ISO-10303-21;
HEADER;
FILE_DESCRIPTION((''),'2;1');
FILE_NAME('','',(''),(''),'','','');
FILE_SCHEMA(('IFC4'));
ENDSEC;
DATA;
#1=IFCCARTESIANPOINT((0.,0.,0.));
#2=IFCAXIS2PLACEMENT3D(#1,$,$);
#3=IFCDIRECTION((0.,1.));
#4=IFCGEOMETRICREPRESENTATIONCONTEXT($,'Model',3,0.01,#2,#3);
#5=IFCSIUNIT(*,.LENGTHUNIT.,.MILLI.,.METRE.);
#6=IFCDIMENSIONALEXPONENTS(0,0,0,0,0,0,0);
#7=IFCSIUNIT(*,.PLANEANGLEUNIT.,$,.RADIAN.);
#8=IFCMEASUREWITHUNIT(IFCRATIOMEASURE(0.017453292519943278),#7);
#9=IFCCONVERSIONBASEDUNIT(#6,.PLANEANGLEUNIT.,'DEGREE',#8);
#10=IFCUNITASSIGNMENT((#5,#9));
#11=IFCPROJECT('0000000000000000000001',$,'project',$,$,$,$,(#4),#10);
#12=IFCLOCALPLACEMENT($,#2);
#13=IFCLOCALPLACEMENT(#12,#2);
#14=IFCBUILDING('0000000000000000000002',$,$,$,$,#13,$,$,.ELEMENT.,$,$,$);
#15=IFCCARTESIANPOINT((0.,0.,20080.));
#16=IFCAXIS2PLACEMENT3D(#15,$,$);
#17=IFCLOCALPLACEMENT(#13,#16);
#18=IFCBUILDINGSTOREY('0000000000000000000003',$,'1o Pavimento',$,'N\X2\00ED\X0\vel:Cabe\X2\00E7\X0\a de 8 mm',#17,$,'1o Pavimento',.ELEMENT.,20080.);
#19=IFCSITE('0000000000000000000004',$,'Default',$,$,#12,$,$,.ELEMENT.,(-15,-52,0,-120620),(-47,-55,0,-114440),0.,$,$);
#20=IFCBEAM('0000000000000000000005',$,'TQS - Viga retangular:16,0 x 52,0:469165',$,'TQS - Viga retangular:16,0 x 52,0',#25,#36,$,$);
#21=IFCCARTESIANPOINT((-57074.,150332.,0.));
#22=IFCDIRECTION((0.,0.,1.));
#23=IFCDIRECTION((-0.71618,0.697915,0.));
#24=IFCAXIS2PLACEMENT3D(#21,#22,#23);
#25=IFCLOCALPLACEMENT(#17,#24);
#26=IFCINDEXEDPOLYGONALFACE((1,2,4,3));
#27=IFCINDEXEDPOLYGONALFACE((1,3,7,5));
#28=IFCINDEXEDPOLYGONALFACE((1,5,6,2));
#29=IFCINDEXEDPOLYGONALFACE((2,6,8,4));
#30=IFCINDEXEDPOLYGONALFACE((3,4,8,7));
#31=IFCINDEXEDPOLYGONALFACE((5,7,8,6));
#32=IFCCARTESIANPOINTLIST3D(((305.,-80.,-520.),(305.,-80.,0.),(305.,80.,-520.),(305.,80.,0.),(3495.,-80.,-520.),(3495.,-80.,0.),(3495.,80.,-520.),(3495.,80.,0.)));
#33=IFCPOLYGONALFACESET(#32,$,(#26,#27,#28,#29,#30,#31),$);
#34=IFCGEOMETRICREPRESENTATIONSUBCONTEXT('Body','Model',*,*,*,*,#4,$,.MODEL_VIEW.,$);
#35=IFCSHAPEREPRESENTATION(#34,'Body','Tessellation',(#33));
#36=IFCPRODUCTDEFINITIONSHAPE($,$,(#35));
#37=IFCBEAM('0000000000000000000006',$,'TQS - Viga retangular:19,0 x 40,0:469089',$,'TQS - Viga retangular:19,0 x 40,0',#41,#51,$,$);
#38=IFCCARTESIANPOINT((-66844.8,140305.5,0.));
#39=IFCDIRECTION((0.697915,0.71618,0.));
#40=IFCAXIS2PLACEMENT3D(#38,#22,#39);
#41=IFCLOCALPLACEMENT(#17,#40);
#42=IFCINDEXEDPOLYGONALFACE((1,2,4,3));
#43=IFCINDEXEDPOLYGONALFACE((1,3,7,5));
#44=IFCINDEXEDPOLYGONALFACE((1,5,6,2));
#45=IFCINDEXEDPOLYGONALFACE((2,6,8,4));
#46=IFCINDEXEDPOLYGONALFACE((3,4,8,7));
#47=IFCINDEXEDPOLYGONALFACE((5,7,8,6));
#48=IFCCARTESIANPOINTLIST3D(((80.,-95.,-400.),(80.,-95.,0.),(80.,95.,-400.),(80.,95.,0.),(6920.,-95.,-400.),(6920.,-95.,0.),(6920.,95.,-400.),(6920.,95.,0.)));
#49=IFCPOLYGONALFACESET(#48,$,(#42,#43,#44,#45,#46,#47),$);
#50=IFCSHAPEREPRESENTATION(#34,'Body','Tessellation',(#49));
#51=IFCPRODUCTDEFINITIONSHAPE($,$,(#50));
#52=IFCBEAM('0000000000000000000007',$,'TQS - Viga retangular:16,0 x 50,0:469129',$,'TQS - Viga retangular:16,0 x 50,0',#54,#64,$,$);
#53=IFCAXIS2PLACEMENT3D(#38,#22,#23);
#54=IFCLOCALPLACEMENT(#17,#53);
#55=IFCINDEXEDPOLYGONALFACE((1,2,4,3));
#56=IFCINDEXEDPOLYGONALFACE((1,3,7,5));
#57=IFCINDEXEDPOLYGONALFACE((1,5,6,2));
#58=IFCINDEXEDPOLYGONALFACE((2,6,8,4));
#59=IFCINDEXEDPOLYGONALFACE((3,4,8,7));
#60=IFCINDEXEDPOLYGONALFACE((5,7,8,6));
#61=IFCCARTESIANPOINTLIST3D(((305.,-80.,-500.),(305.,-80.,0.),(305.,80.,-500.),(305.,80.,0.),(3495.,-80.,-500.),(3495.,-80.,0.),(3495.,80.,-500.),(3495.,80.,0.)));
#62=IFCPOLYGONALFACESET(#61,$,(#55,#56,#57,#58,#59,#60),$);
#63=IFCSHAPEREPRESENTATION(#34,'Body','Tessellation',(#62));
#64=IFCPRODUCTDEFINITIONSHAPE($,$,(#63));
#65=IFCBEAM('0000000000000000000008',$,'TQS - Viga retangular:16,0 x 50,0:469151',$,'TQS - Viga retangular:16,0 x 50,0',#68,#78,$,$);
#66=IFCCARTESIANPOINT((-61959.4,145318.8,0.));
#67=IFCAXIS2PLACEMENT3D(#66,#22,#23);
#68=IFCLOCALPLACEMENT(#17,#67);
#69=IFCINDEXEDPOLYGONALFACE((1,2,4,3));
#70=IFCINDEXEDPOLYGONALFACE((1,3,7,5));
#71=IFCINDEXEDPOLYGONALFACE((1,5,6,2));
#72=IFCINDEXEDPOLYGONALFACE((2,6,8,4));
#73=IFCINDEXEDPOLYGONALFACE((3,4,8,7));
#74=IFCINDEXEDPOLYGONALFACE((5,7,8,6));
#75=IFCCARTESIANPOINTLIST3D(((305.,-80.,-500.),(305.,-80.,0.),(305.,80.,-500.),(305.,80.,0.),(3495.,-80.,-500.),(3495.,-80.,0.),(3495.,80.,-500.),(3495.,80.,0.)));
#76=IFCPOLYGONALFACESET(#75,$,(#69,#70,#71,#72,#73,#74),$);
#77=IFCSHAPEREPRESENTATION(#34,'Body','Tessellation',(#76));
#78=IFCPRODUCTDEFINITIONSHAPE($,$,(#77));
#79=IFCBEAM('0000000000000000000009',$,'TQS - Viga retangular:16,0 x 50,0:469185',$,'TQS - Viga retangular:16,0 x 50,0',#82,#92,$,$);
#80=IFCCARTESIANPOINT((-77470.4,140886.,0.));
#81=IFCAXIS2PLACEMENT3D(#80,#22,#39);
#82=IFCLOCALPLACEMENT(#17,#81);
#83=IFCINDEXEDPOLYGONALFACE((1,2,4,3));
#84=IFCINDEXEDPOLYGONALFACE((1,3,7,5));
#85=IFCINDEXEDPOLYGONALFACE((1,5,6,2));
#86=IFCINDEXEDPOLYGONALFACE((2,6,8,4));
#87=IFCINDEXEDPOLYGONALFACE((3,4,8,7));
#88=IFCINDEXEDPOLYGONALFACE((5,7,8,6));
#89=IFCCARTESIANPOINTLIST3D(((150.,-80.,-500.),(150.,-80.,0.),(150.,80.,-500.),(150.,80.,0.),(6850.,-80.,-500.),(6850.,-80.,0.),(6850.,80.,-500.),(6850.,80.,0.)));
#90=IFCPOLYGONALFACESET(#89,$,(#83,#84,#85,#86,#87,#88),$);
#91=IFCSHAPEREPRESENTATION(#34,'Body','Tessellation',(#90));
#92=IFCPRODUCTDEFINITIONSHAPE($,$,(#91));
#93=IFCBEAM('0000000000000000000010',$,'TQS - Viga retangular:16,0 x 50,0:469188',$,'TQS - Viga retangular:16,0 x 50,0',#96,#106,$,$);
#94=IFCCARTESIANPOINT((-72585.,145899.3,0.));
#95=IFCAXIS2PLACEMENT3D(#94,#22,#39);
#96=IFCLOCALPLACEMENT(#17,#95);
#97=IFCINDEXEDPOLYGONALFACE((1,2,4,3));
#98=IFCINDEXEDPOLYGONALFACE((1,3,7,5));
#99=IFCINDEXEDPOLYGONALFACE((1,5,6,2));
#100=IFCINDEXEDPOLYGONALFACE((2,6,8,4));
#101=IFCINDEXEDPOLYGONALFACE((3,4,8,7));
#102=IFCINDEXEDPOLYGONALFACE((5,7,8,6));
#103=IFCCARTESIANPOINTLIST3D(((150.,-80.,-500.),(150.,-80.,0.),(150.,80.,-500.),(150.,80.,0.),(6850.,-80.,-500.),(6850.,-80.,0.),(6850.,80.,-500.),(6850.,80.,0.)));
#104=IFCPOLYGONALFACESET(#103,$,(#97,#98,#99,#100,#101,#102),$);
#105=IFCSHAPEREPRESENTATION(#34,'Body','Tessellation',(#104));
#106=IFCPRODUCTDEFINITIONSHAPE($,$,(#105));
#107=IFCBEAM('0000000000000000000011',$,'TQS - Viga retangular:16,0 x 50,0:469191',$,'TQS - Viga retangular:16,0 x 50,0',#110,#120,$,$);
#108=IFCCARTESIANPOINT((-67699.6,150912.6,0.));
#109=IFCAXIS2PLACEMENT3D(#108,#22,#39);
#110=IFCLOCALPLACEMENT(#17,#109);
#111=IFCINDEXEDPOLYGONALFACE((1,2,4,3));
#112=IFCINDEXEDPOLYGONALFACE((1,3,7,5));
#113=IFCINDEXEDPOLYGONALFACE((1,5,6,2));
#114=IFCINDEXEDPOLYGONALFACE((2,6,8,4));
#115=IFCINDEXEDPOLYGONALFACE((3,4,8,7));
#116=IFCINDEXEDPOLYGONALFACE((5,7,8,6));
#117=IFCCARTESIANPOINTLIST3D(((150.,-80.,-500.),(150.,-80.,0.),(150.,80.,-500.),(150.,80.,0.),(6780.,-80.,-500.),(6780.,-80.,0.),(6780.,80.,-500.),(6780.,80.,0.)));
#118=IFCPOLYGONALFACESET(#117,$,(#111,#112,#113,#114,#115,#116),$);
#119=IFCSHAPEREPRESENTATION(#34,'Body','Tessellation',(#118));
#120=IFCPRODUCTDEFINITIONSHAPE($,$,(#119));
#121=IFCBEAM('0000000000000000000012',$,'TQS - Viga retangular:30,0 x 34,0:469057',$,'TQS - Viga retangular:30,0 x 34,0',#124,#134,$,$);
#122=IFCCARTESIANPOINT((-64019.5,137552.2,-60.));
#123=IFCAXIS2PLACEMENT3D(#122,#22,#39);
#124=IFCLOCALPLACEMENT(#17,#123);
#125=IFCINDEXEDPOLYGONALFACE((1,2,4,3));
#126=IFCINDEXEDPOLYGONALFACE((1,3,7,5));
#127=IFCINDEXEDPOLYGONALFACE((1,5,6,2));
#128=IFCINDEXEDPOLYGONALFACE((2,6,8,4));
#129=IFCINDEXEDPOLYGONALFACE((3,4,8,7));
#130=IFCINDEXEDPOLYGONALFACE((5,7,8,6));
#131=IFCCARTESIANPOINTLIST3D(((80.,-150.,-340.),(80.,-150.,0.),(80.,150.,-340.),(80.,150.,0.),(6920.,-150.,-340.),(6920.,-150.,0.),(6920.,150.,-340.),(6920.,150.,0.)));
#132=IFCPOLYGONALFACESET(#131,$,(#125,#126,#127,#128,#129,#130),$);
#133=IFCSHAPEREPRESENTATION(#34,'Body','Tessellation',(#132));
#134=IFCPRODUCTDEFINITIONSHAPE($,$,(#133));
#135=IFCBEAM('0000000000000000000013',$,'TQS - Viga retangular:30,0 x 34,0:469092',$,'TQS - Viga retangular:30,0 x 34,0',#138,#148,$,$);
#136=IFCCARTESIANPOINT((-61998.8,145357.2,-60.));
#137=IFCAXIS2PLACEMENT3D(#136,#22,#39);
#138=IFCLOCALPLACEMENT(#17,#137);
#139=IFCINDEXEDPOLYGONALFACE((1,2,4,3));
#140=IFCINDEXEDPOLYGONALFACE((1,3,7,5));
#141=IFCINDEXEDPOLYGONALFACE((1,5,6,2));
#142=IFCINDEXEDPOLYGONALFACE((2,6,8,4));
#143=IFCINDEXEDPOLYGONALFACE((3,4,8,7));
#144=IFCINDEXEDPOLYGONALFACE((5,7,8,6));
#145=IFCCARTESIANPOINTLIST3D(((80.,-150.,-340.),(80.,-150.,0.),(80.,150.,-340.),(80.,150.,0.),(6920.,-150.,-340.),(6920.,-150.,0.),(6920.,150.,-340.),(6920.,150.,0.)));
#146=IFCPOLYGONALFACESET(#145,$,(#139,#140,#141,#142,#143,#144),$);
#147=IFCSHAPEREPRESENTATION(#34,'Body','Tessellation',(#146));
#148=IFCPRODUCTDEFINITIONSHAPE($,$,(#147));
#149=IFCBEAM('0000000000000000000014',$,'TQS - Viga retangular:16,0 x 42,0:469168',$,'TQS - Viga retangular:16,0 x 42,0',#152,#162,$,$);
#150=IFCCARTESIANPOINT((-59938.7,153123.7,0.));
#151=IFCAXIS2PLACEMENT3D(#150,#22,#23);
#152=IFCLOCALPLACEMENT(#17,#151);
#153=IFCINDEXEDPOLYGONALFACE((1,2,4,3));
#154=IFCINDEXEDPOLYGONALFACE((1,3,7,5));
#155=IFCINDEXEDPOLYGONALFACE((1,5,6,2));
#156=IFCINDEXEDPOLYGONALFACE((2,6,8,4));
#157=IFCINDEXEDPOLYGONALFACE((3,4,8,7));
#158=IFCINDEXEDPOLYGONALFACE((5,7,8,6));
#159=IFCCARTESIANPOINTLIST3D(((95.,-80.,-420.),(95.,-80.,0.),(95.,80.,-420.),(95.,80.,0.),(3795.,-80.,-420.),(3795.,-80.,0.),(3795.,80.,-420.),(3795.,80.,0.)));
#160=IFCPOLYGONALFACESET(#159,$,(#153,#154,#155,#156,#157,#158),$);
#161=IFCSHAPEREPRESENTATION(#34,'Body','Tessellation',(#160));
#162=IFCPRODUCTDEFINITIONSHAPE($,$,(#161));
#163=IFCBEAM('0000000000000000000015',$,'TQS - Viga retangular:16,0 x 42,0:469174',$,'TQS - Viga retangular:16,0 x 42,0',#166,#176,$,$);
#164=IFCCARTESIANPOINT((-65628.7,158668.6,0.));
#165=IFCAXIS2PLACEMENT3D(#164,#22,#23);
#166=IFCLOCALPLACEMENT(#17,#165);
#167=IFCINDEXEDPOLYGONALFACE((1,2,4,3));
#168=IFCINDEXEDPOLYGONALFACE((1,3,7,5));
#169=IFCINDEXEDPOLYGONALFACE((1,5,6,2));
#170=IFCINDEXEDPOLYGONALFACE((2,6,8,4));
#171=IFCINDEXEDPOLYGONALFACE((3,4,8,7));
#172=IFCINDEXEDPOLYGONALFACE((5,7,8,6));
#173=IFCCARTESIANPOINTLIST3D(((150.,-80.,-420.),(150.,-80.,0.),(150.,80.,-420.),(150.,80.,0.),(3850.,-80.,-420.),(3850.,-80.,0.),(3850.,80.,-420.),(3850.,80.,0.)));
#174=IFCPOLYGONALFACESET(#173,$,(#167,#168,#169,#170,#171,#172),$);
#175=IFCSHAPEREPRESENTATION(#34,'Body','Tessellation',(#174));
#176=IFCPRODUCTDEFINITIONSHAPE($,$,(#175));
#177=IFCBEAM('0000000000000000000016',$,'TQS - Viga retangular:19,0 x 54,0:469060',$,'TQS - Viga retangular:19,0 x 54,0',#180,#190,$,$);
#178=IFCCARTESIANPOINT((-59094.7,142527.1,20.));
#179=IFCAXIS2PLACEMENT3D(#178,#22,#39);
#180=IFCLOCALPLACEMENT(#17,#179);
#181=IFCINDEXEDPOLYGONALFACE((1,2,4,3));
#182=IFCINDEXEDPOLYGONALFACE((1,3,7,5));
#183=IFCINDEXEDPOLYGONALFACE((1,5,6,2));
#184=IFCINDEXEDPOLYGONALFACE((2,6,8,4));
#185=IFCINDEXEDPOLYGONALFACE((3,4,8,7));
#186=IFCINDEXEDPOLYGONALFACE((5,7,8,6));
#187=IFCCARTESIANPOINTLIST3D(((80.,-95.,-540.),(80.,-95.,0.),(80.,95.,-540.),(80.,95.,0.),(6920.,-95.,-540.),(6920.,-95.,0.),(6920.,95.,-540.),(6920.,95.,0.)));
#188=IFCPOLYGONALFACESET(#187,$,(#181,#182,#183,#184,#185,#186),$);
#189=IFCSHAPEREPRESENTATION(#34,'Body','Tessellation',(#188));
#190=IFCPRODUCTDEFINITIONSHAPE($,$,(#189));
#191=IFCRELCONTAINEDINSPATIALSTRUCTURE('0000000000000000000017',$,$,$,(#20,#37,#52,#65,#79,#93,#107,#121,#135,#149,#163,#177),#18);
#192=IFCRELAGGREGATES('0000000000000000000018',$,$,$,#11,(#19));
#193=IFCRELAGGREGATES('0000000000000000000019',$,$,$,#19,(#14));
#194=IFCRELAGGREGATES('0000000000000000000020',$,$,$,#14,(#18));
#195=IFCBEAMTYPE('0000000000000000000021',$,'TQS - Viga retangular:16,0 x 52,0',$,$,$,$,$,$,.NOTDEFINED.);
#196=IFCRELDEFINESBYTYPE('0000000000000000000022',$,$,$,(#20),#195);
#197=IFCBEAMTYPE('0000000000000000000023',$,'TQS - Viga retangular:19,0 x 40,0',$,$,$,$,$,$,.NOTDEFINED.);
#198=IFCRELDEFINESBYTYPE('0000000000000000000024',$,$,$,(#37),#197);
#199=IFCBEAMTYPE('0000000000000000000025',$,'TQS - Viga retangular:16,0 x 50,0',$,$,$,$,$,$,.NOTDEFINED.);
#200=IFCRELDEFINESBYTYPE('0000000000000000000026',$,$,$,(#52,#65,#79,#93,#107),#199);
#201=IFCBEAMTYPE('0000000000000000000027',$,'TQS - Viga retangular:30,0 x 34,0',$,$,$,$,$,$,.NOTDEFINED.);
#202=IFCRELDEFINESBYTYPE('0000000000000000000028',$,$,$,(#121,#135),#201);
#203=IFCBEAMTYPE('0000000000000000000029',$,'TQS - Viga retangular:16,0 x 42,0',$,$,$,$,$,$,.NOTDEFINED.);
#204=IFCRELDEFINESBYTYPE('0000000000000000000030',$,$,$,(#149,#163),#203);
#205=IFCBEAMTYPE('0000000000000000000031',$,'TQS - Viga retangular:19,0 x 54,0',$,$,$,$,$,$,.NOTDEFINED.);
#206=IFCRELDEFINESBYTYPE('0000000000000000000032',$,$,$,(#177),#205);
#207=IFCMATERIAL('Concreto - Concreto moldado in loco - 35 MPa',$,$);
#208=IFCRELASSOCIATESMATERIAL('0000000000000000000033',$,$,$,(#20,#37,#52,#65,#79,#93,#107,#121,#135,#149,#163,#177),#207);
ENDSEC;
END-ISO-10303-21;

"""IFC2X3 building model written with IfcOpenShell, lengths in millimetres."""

from ifc_helpers import new_model, entity, si_unit, converted_unit, direction, frame, frame_2d, origin, origin_2d_with_axis, place, context, subcontext, project, spatial, rectangle, extrude, material, type_object, element, save


model = new_model("IFC2X3")

# Units and contexts
model_context = context("Model", 3, precision=0.01, world=origin(), true_north=direction((0.0, 1.0)))
body_context = subcontext(model_context, "Body", "Model", "MODEL_VIEW")
ifc_project = project(units=[si_unit("LENGTHUNIT", "METRE", prefix="MILLI"), converted_unit("PLANEANGLEUNIT", "DEGREE", entity("IfcRatioMeasure", 0.017453292519943278), si_unit("PLANEANGLEUNIT", "RADIAN"), dimensions=[0, 0, 0, 0, 0, 0, 0])], contexts=[model_context])

# Site, building, storey
site_placement = place(None, origin())
site = spatial("IfcSite", under=ifc_project, at=site_placement, Name="Default", CompositionType="ELEMENT", RefLatitude=(-15, -52, 0, -120620), RefLongitude=(-47, -55, 0, -114440), RefElevation=0.0)
building_placement = place(site_placement, origin())
building = spatial("IfcBuilding", under=site, at=building_placement, CompositionType="ELEMENT")
storey_placement = place(building_placement, frame((0.0, 0.0, 20080.0)))
storey = spatial("IfcBuildingStorey", under=building, at=storey_placement, Name="1o Pavimento", ObjectType="Nível:Cabeça de 8 mm", LongName="1o Pavimento", CompositionType="ELEMENT", Elevation=20080.0)

# Beams
ifc_material_1 = material(Name="Concreto - Concreto moldado in loco - 35 MPa")
beam_type_1 = type_object("IfcBeamType", Name="TQS - Viga retangular:16,0 x 52,0", PredefinedType="NOTDEFINED")
beam_1_placement = place(storey_placement, frame((-57074.0, 150332.0, 0.0), z_axis=(0.0, 0.0, 1.0), x_axis=(-0.71618, 0.697915, 0.0)))
element("IfcBeam", 1, at=beam_1_placement, inside=storey, type_object=beam_type_1, material=ifc_material_1, Name="TQS - Viga retangular:16,0 x 52,0:469165", ObjectType="TQS - Viga retangular:16,0 x 52,0", context=body_context, shape_type="SweptSolid", body=[
    extrude(rectangle(XDim=520.0, YDim=160.0, at=frame_2d((0.0, 0.0), x_axis=(1.0, 0.0))), frame((305.0, 0.0, -260.0), z_axis=(1.0, 0.0, 0.0), x_axis=(0.0, 0.0, -1.0)), (0.0, 0.0, 1.0), 3190.0),
])
beam_type_2 = type_object("IfcBeamType", Name="TQS - Viga retangular:19,0 x 40,0", PredefinedType="NOTDEFINED")
beam_2_placement = place(storey_placement, frame((-66844.8, 140305.5, 0.0), z_axis=(0.0, 0.0, 1.0), x_axis=(0.697915, 0.71618, 0.0)))
element("IfcBeam", 2, at=beam_2_placement, inside=storey, type_object=beam_type_2, material=ifc_material_1, Name="TQS - Viga retangular:19,0 x 40,0:469089", ObjectType="TQS - Viga retangular:19,0 x 40,0", context=body_context, shape_type="SweptSolid", body=[
    extrude(rectangle(XDim=400.0, YDim=190.0, at=frame_2d((0.0, 0.0), x_axis=(1.0, 0.0))), frame((80.0, 0.0, -200.0), z_axis=(1.0, 0.0, 0.0), x_axis=(0.0, 0.0, -1.0)), (0.0, 0.0, 1.0), 6840.0),
])
beam_type_3 = type_object("IfcBeamType", Name="TQS - Viga retangular:16,0 x 50,0", PredefinedType="NOTDEFINED")
beam_3_placement = place(storey_placement, frame((-66844.8, 140305.5, 0.0), z_axis=(0.0, 0.0, 1.0), x_axis=(-0.71618, 0.697915, 0.0)))
element("IfcBeam", 3, at=beam_3_placement, inside=storey, type_object=beam_type_3, material=ifc_material_1, Name="TQS - Viga retangular:16,0 x 50,0:469129", ObjectType="TQS - Viga retangular:16,0 x 50,0", context=body_context, shape_type="SweptSolid", body=[
    extrude(rectangle(XDim=500.0, YDim=160.0, at=frame_2d((0.0, 0.0), x_axis=(1.0, 0.0))), frame((305.0, 0.0, -250.0), z_axis=(1.0, 0.0, 0.0), x_axis=(0.0, 0.0, -1.0)), (0.0, 0.0, 1.0), 3190.0),
])
beam_4_placement = place(storey_placement, frame((-61959.4, 145318.8, 0.0), z_axis=(0.0, 0.0, 1.0), x_axis=(-0.71618, 0.697915, 0.0)))
element("IfcBeam", 4, at=beam_4_placement, inside=storey, type_object=beam_type_3, material=ifc_material_1, Name="TQS - Viga retangular:16,0 x 50,0:469151", ObjectType="TQS - Viga retangular:16,0 x 50,0", context=body_context, shape_type="SweptSolid", body=[
    extrude(rectangle(XDim=500.0, YDim=160.0, at=frame_2d((0.0, 0.0), x_axis=(1.0, 0.0))), frame((305.0, 0.0, -250.0), z_axis=(1.0, 0.0, 0.0), x_axis=(0.0, 0.0, -1.0)), (0.0, 0.0, 1.0), 3190.0),
])
beam_5_placement = place(storey_placement, frame((-77470.4, 140886.0, 0.0), z_axis=(0.0, 0.0, 1.0), x_axis=(0.697915, 0.71618, 0.0)))
element("IfcBeam", 5, at=beam_5_placement, inside=storey, type_object=beam_type_3, material=ifc_material_1, Name="TQS - Viga retangular:16,0 x 50,0:469185", ObjectType="TQS - Viga retangular:16,0 x 50,0", context=body_context, shape_type="SweptSolid", body=[
    extrude(rectangle(XDim=500.0, YDim=160.0, at=frame_2d((0.0, 0.0), x_axis=(1.0, 0.0))), frame((150.0, 0.0, -250.0), z_axis=(1.0, 0.0, 0.0), x_axis=(0.0, 0.0, -1.0)), (0.0, 0.0, 1.0), 6700.0),
])
beam_6_placement = place(storey_placement, frame((-72585.0, 145899.3, 0.0), z_axis=(0.0, 0.0, 1.0), x_axis=(0.697915, 0.71618, 0.0)))
element("IfcBeam", 6, at=beam_6_placement, inside=storey, type_object=beam_type_3, material=ifc_material_1, Name="TQS - Viga retangular:16,0 x 50,0:469188", ObjectType="TQS - Viga retangular:16,0 x 50,0", context=body_context, shape_type="SweptSolid", body=[
    extrude(rectangle(XDim=500.0, YDim=160.0, at=frame_2d((0.0, 0.0), x_axis=(1.0, 0.0))), frame((150.0, 0.0, -250.0), z_axis=(1.0, 0.0, 0.0), x_axis=(0.0, 0.0, -1.0)), (0.0, 0.0, 1.0), 6700.0),
])
beam_7_placement = place(storey_placement, frame((-67699.6, 150912.6, 0.0), z_axis=(0.0, 0.0, 1.0), x_axis=(0.697915, 0.71618, 0.0)))
element("IfcBeam", 7, at=beam_7_placement, inside=storey, type_object=beam_type_3, material=ifc_material_1, Name="TQS - Viga retangular:16,0 x 50,0:469191", ObjectType="TQS - Viga retangular:16,0 x 50,0", context=body_context, shape_type="SweptSolid", body=[
    extrude(rectangle(XDim=500.0, YDim=160.0, at=frame_2d((0.0, 0.0), x_axis=(1.0, 0.0))), frame((150.0, 0.0, -250.0), z_axis=(1.0, 0.0, 0.0), x_axis=(0.0, 0.0, -1.0)), (0.0, 0.0, 1.0), 6630.0),
])
beam_type_4 = type_object("IfcBeamType", Name="TQS - Viga retangular:30,0 x 34,0", PredefinedType="NOTDEFINED")
beam_8_placement = place(storey_placement, frame((-64019.5, 137552.2, -60.0), z_axis=(0.0, 0.0, 1.0), x_axis=(0.697915, 0.71618, 0.0)))
element("IfcBeam", 8, at=beam_8_placement, inside=storey, type_object=beam_type_4, material=ifc_material_1, Name="TQS - Viga retangular:30,0 x 34,0:469057", ObjectType="TQS - Viga retangular:30,0 x 34,0", context=body_context, shape_type="SweptSolid", body=[
    extrude(rectangle(XDim=340.0, YDim=300.0, at=frame_2d((0.0, 0.0), x_axis=(1.0, 0.0))), frame((80.0, 0.0, -170.0), z_axis=(1.0, 0.0, 0.0), x_axis=(0.0, 0.0, -1.0)), (0.0, 0.0, 1.0), 6840.0),
])
beam_9_placement = place(storey_placement, frame((-61998.8, 145357.2, -60.0), z_axis=(0.0, 0.0, 1.0), x_axis=(0.697915, 0.71618, 0.0)))
element("IfcBeam", 9, at=beam_9_placement, inside=storey, type_object=beam_type_4, material=ifc_material_1, Name="TQS - Viga retangular:30,0 x 34,0:469092", ObjectType="TQS - Viga retangular:30,0 x 34,0", context=body_context, shape_type="SweptSolid", body=[
    extrude(rectangle(XDim=340.0, YDim=300.0, at=origin_2d_with_axis()), frame((80.0, 0.0, -170.0), z_axis=(1.0, 0.0, 0.0), x_axis=(0.0, 0.0, -1.0)), (0.0, 0.0, 1.0), 6840.0),
])
beam_type_5 = type_object("IfcBeamType", Name="TQS - Viga retangular:16,0 x 42,0", PredefinedType="NOTDEFINED")
beam_10_placement = place(storey_placement, frame((-59938.7, 153123.7, 0.0), z_axis=(0.0, 0.0, 1.0), x_axis=(-0.71618, 0.697915, 0.0)))
element("IfcBeam", 10, at=beam_10_placement, inside=storey, type_object=beam_type_5, material=ifc_material_1, Name="TQS - Viga retangular:16,0 x 42,0:469168", ObjectType="TQS - Viga retangular:16,0 x 42,0", context=body_context, shape_type="SweptSolid", body=[
    extrude(rectangle(XDim=420.0, YDim=160.0, at=frame_2d((0.0, 0.0), x_axis=(1.0, 0.0))), frame((95.0, 0.0, -210.0), z_axis=(1.0, 0.0, 0.0), x_axis=(0.0, 0.0, -1.0)), (0.0, 0.0, 1.0), 3700.0),
])
beam_11_placement = place(storey_placement, frame((-65628.7, 158668.6, 0.0), z_axis=(0.0, 0.0, 1.0), x_axis=(-0.71618, 0.697915, 0.0)))
element("IfcBeam", 11, at=beam_11_placement, inside=storey, type_object=beam_type_5, material=ifc_material_1, Name="TQS - Viga retangular:16,0 x 42,0:469174", ObjectType="TQS - Viga retangular:16,0 x 42,0", context=body_context, shape_type="SweptSolid", body=[
    extrude(rectangle(XDim=420.0, YDim=160.0, at=frame_2d((0.0, 0.0), x_axis=(1.0, 0.0))), frame((150.0, 0.0, -210.0), z_axis=(1.0, 0.0, 0.0), x_axis=(0.0, 0.0, -1.0)), (0.0, 0.0, 1.0), 3700.0),
])
beam_type_6 = type_object("IfcBeamType", Name="TQS - Viga retangular:19,0 x 54,0", PredefinedType="NOTDEFINED")
beam_12_placement = place(storey_placement, frame((-59094.7, 142527.1, 20.0), z_axis=(0.0, 0.0, 1.0), x_axis=(0.697915, 0.71618, 0.0)))
element("IfcBeam", 12, at=beam_12_placement, inside=storey, type_object=beam_type_6, material=ifc_material_1, Name="TQS - Viga retangular:19,0 x 54,0:469060", ObjectType="TQS - Viga retangular:19,0 x 54,0", context=body_context, shape_type="SweptSolid", body=[
    extrude(rectangle(XDim=540.0, YDim=190.0, at=frame_2d((0.0, 0.0), x_axis=(1.0, 0.0))), frame((80.0, 0.0, -270.0), z_axis=(1.0, 0.0, 0.0), x_axis=(0.0, 0.0, -1.0)), (0.0, 0.0, 1.0), 6840.0),
])

save(model, "model.ifc")
